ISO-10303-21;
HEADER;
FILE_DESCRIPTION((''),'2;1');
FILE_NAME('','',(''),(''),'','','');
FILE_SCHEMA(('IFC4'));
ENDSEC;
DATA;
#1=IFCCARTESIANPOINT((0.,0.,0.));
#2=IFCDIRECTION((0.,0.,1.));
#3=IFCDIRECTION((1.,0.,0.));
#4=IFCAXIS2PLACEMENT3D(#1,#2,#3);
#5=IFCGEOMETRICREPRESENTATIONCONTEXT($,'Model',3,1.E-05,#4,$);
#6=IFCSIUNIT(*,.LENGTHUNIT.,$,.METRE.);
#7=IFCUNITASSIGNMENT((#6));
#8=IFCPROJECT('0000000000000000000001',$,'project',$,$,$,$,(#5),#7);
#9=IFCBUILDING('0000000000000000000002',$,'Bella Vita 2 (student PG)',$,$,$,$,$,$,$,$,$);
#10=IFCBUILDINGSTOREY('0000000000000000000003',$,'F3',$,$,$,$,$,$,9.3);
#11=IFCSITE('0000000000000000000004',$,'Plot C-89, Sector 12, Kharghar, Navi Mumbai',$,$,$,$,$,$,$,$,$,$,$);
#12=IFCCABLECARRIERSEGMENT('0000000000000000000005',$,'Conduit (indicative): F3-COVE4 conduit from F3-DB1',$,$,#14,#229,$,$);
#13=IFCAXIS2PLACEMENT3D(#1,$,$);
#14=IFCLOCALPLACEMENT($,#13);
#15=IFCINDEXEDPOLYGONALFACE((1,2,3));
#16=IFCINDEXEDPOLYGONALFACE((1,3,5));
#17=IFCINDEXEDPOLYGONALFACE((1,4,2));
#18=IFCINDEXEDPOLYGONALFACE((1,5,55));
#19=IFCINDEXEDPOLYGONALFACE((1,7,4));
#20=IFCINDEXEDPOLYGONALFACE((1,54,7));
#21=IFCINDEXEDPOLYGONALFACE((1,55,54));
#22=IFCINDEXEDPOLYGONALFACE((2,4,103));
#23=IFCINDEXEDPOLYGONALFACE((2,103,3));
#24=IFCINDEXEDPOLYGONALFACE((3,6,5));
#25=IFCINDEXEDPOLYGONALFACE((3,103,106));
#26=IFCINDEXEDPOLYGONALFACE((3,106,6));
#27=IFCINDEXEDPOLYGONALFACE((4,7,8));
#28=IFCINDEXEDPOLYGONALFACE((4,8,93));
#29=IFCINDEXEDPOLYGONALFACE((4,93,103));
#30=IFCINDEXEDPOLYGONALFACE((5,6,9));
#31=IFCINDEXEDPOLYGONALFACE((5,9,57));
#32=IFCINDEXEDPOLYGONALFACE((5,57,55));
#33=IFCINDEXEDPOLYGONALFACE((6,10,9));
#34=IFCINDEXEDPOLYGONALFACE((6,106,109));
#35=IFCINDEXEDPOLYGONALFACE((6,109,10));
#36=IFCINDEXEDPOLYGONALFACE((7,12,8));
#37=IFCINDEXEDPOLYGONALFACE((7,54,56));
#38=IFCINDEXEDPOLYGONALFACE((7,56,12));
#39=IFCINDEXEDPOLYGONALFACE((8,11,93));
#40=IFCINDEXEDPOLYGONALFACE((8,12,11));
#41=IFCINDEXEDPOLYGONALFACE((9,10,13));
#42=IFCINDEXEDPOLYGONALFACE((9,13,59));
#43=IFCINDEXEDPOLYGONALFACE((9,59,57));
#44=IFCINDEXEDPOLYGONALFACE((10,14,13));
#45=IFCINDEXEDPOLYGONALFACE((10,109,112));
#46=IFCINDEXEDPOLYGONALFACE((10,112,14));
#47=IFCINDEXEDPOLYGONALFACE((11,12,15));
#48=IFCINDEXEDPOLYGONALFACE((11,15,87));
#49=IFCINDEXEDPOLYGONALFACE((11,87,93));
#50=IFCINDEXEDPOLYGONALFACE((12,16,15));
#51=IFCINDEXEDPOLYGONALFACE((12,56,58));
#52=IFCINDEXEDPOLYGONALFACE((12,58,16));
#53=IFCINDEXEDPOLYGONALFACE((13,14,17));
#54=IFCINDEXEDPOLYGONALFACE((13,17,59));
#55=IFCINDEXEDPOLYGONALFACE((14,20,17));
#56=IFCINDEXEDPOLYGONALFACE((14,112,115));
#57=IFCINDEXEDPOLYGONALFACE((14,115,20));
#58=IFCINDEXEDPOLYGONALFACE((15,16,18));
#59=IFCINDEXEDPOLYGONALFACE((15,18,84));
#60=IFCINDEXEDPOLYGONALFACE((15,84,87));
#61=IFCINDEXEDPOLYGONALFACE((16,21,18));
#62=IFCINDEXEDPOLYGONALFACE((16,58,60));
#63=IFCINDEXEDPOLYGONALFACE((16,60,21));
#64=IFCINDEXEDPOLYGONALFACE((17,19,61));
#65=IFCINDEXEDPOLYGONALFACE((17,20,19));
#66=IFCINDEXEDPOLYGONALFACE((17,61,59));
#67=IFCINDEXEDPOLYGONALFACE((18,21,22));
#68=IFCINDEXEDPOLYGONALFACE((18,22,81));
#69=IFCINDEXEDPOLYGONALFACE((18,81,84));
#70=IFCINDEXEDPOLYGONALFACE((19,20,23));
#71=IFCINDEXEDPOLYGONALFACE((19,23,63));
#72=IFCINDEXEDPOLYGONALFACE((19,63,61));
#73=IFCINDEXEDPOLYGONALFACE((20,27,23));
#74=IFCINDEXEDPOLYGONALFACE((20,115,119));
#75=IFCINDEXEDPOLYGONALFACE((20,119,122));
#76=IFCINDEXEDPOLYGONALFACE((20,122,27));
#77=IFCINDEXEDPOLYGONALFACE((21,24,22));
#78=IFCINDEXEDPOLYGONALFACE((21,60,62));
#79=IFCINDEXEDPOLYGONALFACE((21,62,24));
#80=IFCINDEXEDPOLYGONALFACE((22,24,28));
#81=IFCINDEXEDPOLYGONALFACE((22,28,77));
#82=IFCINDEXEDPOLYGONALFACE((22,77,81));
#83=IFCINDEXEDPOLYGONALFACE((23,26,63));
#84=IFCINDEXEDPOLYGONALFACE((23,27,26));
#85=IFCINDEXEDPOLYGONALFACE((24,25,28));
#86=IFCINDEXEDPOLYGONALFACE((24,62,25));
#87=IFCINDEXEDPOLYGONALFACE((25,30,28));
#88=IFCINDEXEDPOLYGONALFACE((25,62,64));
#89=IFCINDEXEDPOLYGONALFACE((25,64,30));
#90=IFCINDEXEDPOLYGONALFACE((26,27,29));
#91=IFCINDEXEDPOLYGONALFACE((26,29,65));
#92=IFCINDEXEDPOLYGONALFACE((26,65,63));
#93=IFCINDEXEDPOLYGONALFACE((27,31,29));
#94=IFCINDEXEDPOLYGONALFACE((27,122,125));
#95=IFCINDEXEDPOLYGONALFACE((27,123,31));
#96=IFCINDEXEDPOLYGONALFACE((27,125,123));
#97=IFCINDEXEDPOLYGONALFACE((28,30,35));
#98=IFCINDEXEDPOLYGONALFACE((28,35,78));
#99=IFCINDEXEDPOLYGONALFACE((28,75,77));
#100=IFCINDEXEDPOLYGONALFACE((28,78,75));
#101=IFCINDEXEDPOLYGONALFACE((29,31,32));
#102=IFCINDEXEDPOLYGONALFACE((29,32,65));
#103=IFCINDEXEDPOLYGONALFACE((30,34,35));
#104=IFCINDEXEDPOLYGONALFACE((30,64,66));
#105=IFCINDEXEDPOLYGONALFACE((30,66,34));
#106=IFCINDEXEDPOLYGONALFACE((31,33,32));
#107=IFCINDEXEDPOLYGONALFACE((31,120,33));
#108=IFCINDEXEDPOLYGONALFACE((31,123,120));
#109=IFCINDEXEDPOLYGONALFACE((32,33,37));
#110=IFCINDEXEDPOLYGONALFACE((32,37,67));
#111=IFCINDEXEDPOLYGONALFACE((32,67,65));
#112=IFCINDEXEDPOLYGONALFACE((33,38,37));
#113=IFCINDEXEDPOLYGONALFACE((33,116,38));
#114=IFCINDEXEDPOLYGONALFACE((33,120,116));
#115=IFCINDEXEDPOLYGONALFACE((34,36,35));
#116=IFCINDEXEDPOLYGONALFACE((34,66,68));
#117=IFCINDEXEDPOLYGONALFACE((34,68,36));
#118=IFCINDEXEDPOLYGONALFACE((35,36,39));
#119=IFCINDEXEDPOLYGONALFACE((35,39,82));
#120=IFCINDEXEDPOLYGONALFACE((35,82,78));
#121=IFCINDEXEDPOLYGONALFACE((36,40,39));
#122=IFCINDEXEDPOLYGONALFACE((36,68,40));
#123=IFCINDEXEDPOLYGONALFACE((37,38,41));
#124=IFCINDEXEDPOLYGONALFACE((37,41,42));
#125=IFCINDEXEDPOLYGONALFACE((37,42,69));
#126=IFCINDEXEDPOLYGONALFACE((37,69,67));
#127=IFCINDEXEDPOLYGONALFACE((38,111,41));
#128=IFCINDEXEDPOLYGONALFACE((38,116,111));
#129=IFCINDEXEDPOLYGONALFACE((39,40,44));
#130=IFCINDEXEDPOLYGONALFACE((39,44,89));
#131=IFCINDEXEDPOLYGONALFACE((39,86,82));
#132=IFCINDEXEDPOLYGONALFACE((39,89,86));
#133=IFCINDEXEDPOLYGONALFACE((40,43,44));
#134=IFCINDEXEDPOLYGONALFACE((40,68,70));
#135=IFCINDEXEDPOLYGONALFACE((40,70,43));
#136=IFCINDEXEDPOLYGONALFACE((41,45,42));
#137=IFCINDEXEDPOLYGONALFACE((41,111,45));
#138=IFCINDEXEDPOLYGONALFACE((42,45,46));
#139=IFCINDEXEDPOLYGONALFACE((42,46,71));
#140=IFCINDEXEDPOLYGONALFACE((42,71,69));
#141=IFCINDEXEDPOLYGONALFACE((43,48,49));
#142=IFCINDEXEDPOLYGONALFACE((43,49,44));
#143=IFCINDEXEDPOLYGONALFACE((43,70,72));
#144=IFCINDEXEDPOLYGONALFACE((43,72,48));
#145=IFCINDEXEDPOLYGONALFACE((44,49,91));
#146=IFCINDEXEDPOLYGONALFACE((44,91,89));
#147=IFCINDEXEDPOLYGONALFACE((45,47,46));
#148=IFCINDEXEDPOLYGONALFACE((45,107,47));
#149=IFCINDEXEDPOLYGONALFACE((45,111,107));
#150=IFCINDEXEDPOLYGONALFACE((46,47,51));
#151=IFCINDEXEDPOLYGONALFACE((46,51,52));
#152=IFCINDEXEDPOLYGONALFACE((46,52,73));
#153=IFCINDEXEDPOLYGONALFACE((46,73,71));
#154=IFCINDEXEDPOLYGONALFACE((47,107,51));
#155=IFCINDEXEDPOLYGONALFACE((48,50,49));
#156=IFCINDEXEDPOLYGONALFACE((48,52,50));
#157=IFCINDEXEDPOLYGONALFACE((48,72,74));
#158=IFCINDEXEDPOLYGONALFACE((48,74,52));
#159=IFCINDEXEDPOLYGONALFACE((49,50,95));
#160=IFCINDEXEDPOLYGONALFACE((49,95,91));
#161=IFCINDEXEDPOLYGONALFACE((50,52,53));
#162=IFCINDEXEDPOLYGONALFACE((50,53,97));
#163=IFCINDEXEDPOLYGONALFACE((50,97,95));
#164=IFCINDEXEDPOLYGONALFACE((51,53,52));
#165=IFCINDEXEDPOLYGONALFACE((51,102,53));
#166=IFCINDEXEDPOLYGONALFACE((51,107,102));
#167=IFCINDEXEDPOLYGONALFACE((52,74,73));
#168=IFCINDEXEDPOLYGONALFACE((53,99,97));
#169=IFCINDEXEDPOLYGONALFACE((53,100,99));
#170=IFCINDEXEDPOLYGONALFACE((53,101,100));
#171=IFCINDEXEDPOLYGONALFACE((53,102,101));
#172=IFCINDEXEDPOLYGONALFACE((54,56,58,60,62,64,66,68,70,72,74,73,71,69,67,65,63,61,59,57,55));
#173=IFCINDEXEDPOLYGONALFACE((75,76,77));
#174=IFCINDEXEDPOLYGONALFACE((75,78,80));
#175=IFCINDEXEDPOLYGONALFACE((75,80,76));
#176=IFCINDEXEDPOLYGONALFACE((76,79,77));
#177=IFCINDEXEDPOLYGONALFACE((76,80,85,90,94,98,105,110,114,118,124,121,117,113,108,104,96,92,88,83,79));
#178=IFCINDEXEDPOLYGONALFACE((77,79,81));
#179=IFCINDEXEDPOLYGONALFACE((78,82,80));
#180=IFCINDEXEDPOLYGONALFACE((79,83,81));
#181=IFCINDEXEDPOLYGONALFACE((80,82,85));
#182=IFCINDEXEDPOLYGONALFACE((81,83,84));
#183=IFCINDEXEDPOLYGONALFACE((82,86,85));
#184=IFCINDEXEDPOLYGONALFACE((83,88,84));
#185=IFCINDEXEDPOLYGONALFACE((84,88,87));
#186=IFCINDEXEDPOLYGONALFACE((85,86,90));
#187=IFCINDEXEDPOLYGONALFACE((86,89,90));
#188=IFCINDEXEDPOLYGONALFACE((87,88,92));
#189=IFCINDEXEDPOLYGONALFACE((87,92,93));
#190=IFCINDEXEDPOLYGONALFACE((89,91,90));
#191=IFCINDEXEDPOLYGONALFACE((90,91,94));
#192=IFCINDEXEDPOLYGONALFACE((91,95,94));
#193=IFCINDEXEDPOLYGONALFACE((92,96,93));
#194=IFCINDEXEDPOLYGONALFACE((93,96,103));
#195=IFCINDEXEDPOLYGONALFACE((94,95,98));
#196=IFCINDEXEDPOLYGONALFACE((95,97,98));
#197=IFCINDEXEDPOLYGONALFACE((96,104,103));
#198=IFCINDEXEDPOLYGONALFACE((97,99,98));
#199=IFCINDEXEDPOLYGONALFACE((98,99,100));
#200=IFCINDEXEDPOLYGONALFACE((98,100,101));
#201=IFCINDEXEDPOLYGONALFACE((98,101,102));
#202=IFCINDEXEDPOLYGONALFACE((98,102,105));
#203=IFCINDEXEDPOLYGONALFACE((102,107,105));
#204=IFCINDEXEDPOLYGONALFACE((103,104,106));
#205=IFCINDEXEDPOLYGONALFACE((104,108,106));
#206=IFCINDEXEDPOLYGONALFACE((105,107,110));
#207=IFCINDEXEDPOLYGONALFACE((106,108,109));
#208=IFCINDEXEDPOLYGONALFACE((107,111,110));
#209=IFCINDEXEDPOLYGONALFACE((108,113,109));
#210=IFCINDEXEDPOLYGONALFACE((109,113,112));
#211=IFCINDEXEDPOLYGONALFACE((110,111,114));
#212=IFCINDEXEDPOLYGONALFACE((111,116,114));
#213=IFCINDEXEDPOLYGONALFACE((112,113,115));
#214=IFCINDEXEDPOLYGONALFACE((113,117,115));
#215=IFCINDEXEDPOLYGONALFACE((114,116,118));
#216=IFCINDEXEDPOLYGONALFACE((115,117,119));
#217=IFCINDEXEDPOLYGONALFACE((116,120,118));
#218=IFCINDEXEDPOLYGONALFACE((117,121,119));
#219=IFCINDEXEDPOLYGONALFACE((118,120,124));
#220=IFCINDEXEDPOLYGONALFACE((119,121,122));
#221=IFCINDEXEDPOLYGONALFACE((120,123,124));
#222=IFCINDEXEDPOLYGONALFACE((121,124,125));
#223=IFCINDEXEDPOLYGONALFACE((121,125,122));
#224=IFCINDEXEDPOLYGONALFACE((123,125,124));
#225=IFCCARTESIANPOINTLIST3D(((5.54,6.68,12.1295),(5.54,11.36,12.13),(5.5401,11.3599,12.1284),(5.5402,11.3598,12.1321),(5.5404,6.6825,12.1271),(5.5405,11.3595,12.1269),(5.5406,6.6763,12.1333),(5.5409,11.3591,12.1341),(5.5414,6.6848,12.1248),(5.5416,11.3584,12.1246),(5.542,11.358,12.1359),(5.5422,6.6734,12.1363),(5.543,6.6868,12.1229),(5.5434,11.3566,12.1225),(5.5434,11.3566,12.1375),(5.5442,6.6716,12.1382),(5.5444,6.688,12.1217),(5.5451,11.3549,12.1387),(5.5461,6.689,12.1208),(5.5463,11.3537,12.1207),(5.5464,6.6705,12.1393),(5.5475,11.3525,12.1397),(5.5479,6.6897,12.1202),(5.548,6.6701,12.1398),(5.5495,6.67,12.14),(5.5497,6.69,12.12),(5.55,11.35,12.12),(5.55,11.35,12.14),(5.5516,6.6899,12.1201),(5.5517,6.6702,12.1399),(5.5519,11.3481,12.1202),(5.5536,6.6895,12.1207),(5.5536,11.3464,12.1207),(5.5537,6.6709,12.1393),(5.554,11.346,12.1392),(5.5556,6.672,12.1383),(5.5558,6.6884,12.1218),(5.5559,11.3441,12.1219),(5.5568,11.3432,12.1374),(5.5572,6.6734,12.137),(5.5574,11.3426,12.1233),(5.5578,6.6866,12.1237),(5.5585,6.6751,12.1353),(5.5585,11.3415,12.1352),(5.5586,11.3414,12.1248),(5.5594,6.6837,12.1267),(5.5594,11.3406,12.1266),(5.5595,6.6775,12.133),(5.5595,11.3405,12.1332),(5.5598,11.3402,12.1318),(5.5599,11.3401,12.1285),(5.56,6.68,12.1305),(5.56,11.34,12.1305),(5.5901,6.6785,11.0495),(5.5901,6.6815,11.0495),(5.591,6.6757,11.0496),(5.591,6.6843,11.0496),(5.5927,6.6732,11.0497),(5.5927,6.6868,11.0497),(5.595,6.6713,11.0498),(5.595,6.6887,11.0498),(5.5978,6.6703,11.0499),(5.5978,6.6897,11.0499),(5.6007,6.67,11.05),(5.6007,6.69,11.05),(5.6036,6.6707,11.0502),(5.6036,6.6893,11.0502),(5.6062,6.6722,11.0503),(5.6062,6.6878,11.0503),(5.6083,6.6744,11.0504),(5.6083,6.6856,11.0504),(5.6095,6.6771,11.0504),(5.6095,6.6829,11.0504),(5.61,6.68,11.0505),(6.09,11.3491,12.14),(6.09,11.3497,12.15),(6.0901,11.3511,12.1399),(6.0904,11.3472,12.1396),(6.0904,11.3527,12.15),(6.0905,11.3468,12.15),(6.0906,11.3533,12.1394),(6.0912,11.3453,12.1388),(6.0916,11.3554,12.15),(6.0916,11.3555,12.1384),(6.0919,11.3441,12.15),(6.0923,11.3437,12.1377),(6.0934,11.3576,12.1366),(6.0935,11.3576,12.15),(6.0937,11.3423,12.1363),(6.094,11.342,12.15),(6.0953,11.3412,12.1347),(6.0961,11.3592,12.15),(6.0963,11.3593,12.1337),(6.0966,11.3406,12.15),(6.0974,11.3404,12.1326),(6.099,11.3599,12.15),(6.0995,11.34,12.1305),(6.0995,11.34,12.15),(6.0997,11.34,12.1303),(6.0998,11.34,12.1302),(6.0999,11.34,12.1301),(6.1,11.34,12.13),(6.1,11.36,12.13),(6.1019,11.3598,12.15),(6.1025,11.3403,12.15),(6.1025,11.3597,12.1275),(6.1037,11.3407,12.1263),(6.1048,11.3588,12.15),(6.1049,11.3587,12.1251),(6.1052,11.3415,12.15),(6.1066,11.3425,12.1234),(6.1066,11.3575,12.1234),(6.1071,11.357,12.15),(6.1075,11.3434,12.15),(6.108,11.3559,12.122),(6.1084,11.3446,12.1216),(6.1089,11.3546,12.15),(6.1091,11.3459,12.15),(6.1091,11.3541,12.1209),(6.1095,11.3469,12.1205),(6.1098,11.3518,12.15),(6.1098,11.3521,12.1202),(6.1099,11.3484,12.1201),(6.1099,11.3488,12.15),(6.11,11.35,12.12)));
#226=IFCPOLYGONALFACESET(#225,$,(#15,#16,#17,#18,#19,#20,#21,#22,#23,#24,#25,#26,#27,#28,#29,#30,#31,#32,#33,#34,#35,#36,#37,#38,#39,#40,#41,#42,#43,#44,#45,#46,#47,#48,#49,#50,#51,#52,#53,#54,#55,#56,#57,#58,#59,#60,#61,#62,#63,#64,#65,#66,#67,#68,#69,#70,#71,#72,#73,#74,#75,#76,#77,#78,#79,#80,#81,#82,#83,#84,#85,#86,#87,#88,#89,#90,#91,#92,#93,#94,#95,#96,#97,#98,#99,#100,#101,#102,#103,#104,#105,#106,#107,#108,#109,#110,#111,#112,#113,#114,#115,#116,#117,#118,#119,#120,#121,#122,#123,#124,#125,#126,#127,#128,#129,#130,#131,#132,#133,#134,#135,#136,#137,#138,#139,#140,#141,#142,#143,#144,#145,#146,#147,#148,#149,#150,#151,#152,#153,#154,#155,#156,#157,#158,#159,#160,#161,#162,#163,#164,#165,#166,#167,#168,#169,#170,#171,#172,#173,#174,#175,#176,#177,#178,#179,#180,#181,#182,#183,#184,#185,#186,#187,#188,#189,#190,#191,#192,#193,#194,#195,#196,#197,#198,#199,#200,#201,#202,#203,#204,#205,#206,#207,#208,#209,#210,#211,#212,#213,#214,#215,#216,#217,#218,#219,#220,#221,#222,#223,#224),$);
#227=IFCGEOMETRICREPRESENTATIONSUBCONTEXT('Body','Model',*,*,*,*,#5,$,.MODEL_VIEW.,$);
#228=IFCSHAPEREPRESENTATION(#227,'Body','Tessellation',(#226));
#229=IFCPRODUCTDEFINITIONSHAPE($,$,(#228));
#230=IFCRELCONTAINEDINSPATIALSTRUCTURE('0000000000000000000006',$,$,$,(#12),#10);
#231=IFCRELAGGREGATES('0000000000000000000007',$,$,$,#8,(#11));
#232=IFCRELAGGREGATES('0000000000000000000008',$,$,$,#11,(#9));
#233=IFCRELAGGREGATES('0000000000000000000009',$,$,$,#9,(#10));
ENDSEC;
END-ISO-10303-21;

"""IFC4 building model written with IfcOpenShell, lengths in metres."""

from ifc_helpers import new_model, entity, si_unit, origin, origin_with_axes, place, context, subcontext, project, spatial, element, save


model = new_model("IFC4")

# Units and contexts
model_context = context("Model", 3, precision=1e-05, world=origin_with_axes())
body_context = subcontext(model_context, "Body", "Model", "MODEL_VIEW")
ifc_project = project(units=[si_unit("LENGTHUNIT", "METRE")], contexts=[model_context])

# Site, building, storey
site = spatial("IfcSite", under=ifc_project, Name="Plot C-89, Sector 12, Kharghar, Navi Mumbai")
building = spatial("IfcBuilding", under=site, Name="Bella Vita 2 (student PG)")
storey = spatial("IfcBuildingStorey", under=building, Name="F3", Elevation=9.3)

# Cable carrier segment
cable_carrier_segment_1_placement = place(None, origin())
element("IfcCableCarrierSegment", 1, at=cable_carrier_segment_1_placement, inside=storey, Name="Conduit (indicative): F3-COVE4 conduit from F3-DB1", context=body_context, shape_type="AdvancedSweptSolid", body=[
    entity("IfcSweptDiskSolid", entity("IfcPolyline", [entity("IfcCartesianPoint", [5.6, 6.68, 11.05]), entity("IfcCartesianPoint", [5.55, 6.68, 12.13]), entity("IfcCartesianPoint", [5.55, 11.35, 12.13]), entity("IfcCartesianPoint", [6.1, 11.35, 12.13]), entity("IfcCartesianPoint", [6.1, 11.35, 12.15])]), 0.01),
])

save(model, "model.ifc")
